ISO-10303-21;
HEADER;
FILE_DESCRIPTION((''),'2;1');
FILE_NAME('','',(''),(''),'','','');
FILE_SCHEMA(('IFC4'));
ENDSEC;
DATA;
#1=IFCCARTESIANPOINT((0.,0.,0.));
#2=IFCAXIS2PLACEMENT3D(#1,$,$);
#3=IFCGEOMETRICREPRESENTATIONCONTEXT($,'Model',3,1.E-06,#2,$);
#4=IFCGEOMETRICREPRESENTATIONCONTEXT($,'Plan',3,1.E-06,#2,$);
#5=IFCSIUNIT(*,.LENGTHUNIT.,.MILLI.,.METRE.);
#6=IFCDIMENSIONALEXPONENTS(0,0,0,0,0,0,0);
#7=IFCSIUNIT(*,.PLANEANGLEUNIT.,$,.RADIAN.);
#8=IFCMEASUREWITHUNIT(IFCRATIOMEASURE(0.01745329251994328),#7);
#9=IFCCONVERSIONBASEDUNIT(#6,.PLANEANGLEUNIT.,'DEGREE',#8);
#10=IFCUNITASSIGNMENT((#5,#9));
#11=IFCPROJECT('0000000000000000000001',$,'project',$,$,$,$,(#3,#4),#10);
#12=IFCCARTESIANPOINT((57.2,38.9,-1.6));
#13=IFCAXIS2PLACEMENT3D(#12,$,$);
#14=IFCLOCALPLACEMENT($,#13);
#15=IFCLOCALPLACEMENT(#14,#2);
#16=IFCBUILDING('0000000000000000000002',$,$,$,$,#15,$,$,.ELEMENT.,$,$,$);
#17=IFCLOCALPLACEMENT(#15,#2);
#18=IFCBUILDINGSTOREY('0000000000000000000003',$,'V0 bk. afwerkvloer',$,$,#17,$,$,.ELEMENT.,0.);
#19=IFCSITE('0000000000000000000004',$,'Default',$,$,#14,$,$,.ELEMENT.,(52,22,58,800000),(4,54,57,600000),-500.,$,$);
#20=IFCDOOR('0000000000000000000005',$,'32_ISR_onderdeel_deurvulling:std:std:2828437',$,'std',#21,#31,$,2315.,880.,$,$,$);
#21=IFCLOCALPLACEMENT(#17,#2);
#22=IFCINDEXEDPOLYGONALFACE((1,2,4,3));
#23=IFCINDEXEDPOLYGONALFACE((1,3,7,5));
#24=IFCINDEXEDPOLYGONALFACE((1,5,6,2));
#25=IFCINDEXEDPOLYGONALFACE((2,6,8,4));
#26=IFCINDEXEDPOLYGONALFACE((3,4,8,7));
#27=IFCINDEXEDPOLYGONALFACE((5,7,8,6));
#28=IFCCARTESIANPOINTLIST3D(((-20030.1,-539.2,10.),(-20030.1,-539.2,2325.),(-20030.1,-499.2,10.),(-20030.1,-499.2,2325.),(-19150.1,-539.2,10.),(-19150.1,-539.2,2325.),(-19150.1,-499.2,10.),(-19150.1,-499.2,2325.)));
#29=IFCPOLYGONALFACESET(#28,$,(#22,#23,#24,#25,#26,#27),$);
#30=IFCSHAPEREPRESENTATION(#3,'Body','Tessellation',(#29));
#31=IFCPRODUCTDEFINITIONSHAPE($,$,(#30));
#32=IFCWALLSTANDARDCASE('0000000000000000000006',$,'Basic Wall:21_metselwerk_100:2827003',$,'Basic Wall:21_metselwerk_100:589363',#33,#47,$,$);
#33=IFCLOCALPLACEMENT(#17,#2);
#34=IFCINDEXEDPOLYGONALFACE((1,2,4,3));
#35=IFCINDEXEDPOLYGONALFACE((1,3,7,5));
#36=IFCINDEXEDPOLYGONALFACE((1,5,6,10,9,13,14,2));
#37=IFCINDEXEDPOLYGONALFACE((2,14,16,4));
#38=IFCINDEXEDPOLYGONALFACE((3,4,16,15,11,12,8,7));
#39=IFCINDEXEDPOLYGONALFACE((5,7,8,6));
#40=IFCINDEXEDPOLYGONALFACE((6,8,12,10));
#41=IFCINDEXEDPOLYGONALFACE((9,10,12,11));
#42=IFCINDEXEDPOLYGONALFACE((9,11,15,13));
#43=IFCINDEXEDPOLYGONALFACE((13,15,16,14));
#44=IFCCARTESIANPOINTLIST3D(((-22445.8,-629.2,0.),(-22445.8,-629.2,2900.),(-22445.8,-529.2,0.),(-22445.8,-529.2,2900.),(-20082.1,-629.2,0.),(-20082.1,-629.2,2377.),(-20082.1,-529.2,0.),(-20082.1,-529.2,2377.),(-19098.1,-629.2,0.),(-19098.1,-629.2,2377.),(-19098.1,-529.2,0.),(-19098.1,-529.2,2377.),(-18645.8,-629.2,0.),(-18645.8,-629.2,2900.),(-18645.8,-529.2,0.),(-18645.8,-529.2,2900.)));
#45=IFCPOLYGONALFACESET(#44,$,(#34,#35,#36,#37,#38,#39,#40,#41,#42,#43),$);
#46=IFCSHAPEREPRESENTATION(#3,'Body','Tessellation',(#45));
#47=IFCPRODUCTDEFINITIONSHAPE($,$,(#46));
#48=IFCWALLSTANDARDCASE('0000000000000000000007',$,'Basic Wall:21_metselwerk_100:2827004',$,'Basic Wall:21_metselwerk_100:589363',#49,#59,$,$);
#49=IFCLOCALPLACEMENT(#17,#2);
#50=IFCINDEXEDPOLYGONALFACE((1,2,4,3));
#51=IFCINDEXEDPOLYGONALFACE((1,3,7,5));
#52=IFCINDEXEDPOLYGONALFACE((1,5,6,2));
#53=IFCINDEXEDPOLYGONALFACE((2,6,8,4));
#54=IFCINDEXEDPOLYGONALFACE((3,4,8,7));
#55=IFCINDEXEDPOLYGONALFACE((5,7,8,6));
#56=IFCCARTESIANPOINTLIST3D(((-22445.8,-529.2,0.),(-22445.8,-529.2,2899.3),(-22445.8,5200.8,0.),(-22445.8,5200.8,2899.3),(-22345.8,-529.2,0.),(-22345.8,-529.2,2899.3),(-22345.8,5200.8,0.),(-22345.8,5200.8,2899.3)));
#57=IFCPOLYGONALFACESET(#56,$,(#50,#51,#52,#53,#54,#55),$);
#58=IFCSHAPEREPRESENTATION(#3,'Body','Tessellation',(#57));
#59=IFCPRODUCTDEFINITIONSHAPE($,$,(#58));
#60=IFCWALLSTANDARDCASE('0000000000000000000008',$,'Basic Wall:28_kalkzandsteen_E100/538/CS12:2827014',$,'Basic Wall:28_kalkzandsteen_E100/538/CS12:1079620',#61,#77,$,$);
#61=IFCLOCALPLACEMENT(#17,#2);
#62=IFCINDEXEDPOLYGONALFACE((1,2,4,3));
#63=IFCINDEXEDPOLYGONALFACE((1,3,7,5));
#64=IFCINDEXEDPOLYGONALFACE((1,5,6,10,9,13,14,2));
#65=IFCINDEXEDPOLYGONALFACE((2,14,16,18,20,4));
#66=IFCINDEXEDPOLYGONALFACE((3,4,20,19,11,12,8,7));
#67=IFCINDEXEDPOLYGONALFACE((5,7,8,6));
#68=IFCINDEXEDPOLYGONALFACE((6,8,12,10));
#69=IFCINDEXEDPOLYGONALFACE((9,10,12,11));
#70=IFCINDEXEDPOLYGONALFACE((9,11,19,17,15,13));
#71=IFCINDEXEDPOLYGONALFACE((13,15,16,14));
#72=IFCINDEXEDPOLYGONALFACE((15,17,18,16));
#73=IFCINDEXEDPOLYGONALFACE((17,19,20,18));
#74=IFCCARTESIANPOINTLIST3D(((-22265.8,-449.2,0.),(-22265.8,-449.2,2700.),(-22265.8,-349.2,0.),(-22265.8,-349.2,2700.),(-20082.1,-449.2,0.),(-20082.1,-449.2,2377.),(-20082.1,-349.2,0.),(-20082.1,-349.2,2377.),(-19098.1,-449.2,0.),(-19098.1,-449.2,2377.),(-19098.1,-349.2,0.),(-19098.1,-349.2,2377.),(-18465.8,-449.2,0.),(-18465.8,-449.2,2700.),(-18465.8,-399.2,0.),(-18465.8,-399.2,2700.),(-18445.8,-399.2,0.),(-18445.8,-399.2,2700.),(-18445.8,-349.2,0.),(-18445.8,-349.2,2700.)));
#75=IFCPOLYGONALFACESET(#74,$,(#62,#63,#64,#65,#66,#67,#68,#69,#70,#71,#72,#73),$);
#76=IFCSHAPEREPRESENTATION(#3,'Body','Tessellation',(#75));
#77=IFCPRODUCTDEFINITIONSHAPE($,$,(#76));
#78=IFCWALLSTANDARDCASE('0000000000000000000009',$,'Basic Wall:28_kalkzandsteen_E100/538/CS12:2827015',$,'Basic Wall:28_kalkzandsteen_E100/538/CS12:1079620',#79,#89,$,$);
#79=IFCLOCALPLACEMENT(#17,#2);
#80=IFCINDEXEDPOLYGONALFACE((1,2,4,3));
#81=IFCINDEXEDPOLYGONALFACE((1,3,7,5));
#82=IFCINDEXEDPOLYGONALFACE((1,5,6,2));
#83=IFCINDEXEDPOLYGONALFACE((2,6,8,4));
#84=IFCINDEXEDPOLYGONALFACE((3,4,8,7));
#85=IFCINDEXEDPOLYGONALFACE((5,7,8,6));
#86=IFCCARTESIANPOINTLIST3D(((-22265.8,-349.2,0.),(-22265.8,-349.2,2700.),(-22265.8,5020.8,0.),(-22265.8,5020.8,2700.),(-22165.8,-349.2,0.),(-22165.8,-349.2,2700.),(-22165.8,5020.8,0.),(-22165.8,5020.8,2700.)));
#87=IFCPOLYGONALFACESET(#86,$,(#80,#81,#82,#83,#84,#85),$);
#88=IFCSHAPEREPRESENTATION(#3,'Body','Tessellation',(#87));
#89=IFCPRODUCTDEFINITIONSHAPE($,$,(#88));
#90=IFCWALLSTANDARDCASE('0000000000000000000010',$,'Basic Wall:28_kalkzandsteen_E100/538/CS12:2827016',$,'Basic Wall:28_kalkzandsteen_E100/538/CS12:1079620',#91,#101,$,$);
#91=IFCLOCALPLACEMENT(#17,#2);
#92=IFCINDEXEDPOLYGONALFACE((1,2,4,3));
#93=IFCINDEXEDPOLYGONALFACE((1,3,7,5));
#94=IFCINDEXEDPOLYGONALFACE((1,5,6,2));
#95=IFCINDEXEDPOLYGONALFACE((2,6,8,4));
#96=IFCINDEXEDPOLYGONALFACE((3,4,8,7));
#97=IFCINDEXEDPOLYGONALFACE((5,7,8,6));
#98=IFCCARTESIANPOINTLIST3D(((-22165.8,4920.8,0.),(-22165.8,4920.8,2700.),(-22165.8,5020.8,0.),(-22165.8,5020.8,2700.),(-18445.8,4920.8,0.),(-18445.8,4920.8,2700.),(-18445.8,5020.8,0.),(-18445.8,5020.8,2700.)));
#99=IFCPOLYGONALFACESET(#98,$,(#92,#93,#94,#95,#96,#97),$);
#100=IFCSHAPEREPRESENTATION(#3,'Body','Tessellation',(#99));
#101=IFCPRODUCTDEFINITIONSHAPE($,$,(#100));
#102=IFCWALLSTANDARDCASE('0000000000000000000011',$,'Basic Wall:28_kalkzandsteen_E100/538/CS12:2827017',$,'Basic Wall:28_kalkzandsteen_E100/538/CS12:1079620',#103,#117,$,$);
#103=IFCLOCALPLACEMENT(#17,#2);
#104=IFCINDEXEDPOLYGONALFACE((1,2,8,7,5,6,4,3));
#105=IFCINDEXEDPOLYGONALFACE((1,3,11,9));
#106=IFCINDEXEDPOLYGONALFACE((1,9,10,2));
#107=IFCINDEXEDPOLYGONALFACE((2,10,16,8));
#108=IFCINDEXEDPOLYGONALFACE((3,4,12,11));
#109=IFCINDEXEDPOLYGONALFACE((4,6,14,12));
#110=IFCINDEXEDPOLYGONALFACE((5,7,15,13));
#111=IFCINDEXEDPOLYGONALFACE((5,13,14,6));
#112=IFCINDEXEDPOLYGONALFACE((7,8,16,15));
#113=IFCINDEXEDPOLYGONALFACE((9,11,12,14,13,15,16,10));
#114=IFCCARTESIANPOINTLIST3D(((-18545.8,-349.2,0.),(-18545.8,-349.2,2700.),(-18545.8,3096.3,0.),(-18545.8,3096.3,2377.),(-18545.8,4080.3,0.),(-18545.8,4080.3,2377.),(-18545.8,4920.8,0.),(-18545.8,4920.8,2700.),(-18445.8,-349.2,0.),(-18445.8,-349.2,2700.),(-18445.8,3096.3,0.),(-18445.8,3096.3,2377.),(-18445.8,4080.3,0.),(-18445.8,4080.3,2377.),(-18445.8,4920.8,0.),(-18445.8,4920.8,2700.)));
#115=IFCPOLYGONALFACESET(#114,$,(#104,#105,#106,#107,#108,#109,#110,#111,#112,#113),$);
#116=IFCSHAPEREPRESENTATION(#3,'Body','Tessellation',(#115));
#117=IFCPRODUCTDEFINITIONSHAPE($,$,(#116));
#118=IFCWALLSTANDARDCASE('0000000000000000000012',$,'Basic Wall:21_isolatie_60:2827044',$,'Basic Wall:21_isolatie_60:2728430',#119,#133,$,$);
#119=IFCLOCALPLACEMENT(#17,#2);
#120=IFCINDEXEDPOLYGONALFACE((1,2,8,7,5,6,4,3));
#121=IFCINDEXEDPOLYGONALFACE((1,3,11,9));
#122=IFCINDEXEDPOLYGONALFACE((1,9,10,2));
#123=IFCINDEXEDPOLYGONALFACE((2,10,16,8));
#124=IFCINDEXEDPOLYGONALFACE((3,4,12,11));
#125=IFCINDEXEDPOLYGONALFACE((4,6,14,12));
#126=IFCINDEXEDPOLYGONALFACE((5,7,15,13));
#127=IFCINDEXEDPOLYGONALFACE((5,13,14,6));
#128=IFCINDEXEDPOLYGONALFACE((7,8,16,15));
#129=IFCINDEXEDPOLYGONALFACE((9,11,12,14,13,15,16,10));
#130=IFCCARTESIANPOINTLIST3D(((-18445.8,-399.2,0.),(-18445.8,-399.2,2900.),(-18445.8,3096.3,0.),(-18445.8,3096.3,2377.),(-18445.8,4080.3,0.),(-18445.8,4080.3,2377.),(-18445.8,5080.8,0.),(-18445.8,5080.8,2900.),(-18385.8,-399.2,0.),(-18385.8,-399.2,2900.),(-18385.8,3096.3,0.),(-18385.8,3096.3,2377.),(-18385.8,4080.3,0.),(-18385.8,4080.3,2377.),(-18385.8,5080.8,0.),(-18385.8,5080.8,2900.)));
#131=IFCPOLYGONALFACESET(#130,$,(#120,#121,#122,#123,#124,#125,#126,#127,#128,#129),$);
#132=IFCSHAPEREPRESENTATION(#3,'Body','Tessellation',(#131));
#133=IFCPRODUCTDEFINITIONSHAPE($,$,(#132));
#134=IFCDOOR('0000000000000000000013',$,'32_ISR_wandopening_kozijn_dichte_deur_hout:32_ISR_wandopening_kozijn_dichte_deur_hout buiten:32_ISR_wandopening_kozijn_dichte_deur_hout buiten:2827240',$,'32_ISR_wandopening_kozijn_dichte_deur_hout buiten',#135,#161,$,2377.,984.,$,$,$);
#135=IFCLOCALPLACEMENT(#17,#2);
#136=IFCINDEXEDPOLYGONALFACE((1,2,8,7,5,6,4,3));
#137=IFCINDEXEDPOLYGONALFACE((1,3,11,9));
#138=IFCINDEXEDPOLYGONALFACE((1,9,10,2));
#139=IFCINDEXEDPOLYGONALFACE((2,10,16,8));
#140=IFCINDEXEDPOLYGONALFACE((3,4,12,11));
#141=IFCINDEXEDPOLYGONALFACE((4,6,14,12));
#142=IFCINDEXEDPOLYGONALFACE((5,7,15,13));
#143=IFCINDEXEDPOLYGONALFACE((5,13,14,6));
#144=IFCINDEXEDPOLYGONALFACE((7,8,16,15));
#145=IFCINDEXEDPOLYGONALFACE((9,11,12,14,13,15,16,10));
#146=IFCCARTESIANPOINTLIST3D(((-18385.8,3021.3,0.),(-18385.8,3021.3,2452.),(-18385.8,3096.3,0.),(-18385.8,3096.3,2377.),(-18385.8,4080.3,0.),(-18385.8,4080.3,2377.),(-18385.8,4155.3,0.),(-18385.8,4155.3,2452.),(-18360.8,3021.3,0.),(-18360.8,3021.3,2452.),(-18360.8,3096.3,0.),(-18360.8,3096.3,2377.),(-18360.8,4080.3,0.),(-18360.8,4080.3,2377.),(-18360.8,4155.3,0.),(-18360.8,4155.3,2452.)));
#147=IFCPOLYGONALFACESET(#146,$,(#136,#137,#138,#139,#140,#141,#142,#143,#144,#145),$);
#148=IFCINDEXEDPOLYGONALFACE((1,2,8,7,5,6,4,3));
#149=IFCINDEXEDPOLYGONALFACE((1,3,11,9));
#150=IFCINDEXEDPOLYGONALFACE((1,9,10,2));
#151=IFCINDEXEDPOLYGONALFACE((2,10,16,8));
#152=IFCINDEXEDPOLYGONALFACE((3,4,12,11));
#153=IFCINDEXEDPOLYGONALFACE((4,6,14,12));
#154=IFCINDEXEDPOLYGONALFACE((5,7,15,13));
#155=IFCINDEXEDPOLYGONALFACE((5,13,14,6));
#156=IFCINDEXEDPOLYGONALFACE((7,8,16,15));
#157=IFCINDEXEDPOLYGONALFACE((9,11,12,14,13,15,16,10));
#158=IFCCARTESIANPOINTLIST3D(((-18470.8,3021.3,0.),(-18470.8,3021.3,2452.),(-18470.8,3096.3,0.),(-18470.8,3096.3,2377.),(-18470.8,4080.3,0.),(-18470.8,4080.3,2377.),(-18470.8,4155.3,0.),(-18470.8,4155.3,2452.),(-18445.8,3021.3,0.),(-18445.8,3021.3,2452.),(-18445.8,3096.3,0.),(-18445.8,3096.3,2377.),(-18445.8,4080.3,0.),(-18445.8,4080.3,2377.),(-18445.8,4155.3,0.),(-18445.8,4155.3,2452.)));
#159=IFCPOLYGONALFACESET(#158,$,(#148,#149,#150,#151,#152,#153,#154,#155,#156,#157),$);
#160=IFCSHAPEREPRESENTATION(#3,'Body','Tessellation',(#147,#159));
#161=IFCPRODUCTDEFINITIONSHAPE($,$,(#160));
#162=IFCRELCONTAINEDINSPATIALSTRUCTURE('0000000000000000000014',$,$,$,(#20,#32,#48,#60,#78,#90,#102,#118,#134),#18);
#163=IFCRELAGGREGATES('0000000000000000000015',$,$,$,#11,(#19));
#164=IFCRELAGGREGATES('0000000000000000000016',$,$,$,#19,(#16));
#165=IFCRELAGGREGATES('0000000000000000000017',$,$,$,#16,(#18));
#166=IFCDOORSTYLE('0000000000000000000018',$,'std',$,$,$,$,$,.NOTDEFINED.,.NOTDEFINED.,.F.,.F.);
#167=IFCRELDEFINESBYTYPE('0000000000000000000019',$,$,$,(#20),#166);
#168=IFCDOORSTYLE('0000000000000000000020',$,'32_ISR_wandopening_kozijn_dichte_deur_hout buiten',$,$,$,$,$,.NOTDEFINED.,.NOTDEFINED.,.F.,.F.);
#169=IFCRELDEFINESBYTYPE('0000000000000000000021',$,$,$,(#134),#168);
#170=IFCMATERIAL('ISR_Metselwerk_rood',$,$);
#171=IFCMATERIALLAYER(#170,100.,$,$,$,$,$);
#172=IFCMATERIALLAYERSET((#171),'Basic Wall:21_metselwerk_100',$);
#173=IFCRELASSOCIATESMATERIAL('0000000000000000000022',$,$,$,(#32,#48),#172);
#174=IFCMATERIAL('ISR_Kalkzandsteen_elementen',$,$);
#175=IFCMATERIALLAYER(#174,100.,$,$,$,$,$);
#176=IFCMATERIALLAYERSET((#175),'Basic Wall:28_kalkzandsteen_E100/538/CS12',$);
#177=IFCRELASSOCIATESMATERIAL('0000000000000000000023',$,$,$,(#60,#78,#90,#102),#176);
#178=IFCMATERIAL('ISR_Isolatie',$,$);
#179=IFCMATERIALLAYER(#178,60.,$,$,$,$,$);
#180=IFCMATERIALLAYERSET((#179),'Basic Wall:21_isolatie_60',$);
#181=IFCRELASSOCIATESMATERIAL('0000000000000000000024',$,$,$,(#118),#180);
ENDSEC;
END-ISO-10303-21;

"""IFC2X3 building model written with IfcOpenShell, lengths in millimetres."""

from ifc_helpers import new_model, entity, si_unit, converted_unit, frame, frame_2d, origin, origin_2d_with_axis, place, context, project, spatial, polyline, rectangle, outline, extrude, source, transform, mapped, material, layer, layer_set, layer_usage, type_object, type_shapes, element, fill, save


model = new_model("IFC2X3")

# Units and contexts
model_context = context("Model", 3, precision=1e-06, world=origin())
plan_context = context("Plan", 3, precision=1e-06, world=origin())
ifc_project = project(units=[si_unit("LENGTHUNIT", "METRE", prefix="MILLI"), converted_unit("PLANEANGLEUNIT", "DEGREE", entity("IfcRatioMeasure", 0.01745329251994328), si_unit("PLANEANGLEUNIT", "RADIAN"), dimensions=[0, 0, 0, 0, 0, 0, 0])], contexts=[model_context, plan_context])

# Site, building, storey
site_placement = place(None, frame((57.2, 38.9, -1.6)))
site = spatial("IfcSite", under=ifc_project, at=site_placement, Name="Default", CompositionType="ELEMENT", RefLatitude=(52, 22, 58, 800000), RefLongitude=(4, 54, 57, 600000), RefElevation=-500.0)
building_placement = place(site_placement, origin())
building = spatial("IfcBuilding", under=site, at=building_placement, CompositionType="ELEMENT")
storey_placement = place(building_placement, origin())
storey = spatial("IfcBuildingStorey", under=building, at=storey_placement, Name="V0 bk. afwerkvloer", CompositionType="ELEMENT", Elevation=0.0)

# Door
door_style_1 = type_object("IfcDoorStyle", Name="std", ConstructionType="NOTDEFINED", OperationType="NOTDEFINED", ParameterTakesPrecedence=False, Sizeable=False)
shared_shape_1 = source(origin(), model_context, "Body", "SweptSolid", [
    extrude(rectangle(XDim=40.0, YDim=880.0, at=origin_2d_with_axis()), frame((0.0, -34.0, 0.0), z_axis=(0.0, 0.0, 1.0), x_axis=(0.0, -1.0, 0.0)), (0.0, 0.0, 1.0), 2315.0),
])
type_shapes(door_style_1, [shared_shape_1])
door_1_placement = place(storey_placement, frame((-19590.1, -553.2, 10.0), z_axis=(0.0, 0.0, 1.0), x_axis=(-1.0, 0.0, 0.0)))
element("IfcDoor", 1, at=door_1_placement, inside=storey, type_object=door_style_1, Name="32_ISR_onderdeel_deurvulling:std:std:2828437", ObjectType="std", OverallHeight=2315.0, OverallWidth=880.0, context=model_context, shape_type="MappedRepresentation", body=[
    mapped(shared_shape_1, transform((0.0, 0.0, 0.0), scale=1.0)),
])

# Wall, opening
ifc_material_1 = material(Name="ISR_Metselwerk_rood")
ifc_layer_1 = layer(ifc_material_1, 100.0)
ifc_layer_set_1 = layer_set([ifc_layer_1], Name="Basic Wall:21_metselwerk_100")
ifc_layer_usage_1 = layer_usage(ifc_layer_set_1, "AXIS2", "POSITIVE", -50.0)
wall_1_placement = place(storey_placement, frame((-18645.8, -579.2, 0.0), z_axis=(0.0, 0.0, 1.0), x_axis=(-1.0, 0.0, 0.0)))
wall_1 = element("IfcWallStandardCase", 2, at=wall_1_placement, inside=storey, material=ifc_layer_usage_1, Name="Basic Wall:21_metselwerk_100:2827003", ObjectType="Basic Wall:21_metselwerk_100:589363", context=model_context, shape_type="SweptSolid", body=[
    extrude(rectangle(XDim=3800.0, YDim=100.0, at=frame_2d((1900.0, 0.0), x_axis=(-1.0, 0.0))), origin(), (0.0, 0.0, 1.0), 2900.0),
])
opening_1_placement = place(wall_1_placement, origin())
element("IfcOpeningElement", 3, at=opening_1_placement, cuts=wall_1, ObjectType="Opening", context=model_context, shape_type="SweptSolid", body=[
    extrude(rectangle(XDim=2377.0, YDim=984.0, at=frame_2d((0.0, 0.0), x_axis=(0.0, 1.0))), frame((944.2, -1654.0, 1188.5), z_axis=(0.0, 1.0, 0.0), x_axis=(-1.0, 0.0, 0.0)), (0.0, 0.0, 1.0), 3048.0),
])

# Wall
ifc_layer_usage_2 = layer_usage(ifc_layer_set_1, "AXIS2", "POSITIVE", -50.0)
wall_2_placement = place(storey_placement, frame((-22395.8, -529.2, 0.0), z_axis=(0.0, 0.0, 1.0), x_axis=(0.0, 1.0, 0.0)))
element("IfcWallStandardCase", 4, at=wall_2_placement, inside=storey, material=ifc_layer_usage_2, Name="Basic Wall:21_metselwerk_100:2827004", ObjectType="Basic Wall:21_metselwerk_100:589363", context=model_context, shape_type="SweptSolid", body=[
    extrude(rectangle(XDim=5730.0, YDim=100.0, at=frame_2d((2865.0, 0.0), x_axis=(-1.0, 0.0))), origin(), (0.0, 0.0, 1.0), 2899.3),
])

# Wall, opening
ifc_material_2 = material(Name="ISR_Kalkzandsteen_elementen")
ifc_layer_2 = layer(ifc_material_2, 100.0)
ifc_layer_set_2 = layer_set([ifc_layer_2], Name="Basic Wall:28_kalkzandsteen_E100/538/CS12")
ifc_layer_usage_3 = layer_usage(ifc_layer_set_2, "AXIS2", "POSITIVE", -50.0)
wall_3_placement = place(storey_placement, frame((-18445.8, -399.2, 0.0), z_axis=(0.0, 0.0, 1.0), x_axis=(-1.0, 0.0, 0.0)))
wall_3 = element("IfcWallStandardCase", 5, at=wall_3_placement, inside=storey, material=ifc_layer_usage_3, Name="Basic Wall:28_kalkzandsteen_E100/538/CS12:2827014", ObjectType="Basic Wall:28_kalkzandsteen_E100/538/CS12:1079620", context=model_context, shape_type="SweptSolid", body=[
    extrude(outline(polyline([(0.0, -50.0), (100.0, -50.0), (3720.0, -50.0), (3820.0, -50.0), (3820.0, 50.0), (20.0, 50.0), (20.0, 0.0), (0.0, 0.0), (0.0, -50.0)])), origin(), (0.0, 0.0, 1.0), 2700.0),
])
opening_2_placement = place(wall_3_placement, origin())
element("IfcOpeningElement", 6, at=opening_2_placement, cuts=wall_3, ObjectType="Opening", context=model_context, shape_type="SweptSolid", body=[
    extrude(rectangle(XDim=2377.0, YDim=984.0, at=frame_2d((0.0, 0.0), x_axis=(0.0, 1.0))), frame((1144.2, -1474.0, 1188.5), z_axis=(0.0, 1.0, 0.0), x_axis=(-1.0, 0.0, 0.0)), (0.0, 0.0, 1.0), 3048.0),
])

# Walls
ifc_layer_usage_4 = layer_usage(ifc_layer_set_2, "AXIS2", "POSITIVE", -50.0)
wall_4_placement = place(storey_placement, frame((-22215.8, -349.2, 0.0), z_axis=(0.0, 0.0, 1.0), x_axis=(0.0, 1.0, 0.0)))
element("IfcWallStandardCase", 7, at=wall_4_placement, inside=storey, material=ifc_layer_usage_4, Name="Basic Wall:28_kalkzandsteen_E100/538/CS12:2827015", ObjectType="Basic Wall:28_kalkzandsteen_E100/538/CS12:1079620", context=model_context, shape_type="SweptSolid", body=[
    extrude(rectangle(XDim=5370.0, YDim=100.0, at=frame_2d((2685.0, 0.0), x_axis=(-1.0, 0.0))), origin(), (0.0, 0.0, 1.0), 2700.0),
])
ifc_layer_usage_5 = layer_usage(ifc_layer_set_2, "AXIS2", "POSITIVE", -50.0)
wall_5_placement = place(storey_placement, frame((-22165.8, 4970.8, 0.0)))
element("IfcWallStandardCase", 8, at=wall_5_placement, inside=storey, material=ifc_layer_usage_5, Name="Basic Wall:28_kalkzandsteen_E100/538/CS12:2827016", ObjectType="Basic Wall:28_kalkzandsteen_E100/538/CS12:1079620", context=model_context, shape_type="SweptSolid", body=[
    extrude(rectangle(XDim=3720.0, YDim=100.0, at=frame_2d((1860.0, 0.0), x_axis=(-1.0, 0.0))), origin(), (0.0, 0.0, 1.0), 2700.0),
])

# Wall, opening
ifc_layer_usage_6 = layer_usage(ifc_layer_set_2, "AXIS2", "POSITIVE", -50.0)
wall_6_placement = place(storey_placement, frame((-18495.8, 4920.8, 0.0), z_axis=(0.0, 0.0, 1.0), x_axis=(0.0, -1.0, 0.0)))
wall_6 = element("IfcWallStandardCase", 9, at=wall_6_placement, inside=storey, material=ifc_layer_usage_6, Name="Basic Wall:28_kalkzandsteen_E100/538/CS12:2827017", ObjectType="Basic Wall:28_kalkzandsteen_E100/538/CS12:1079620", context=model_context, shape_type="SweptSolid", body=[
    extrude(rectangle(XDim=5270.0, YDim=100.0, at=frame_2d((2635.0, 0.0), x_axis=(-1.0, 0.0))), origin(), (0.0, 0.0, 1.0), 2700.0),
])
opening_3_placement = place(wall_6_placement, origin())
element("IfcOpeningElement", 10, at=opening_3_placement, cuts=wall_6, ObjectType="Opening", context=model_context, shape_type="SweptSolid", body=[
    extrude(rectangle(XDim=2377.0, YDim=984.0, at=frame_2d((0.0, 0.0), x_axis=(0.0, 1.0))), frame((1332.4, -1474.0, 1188.5), z_axis=(0.0, 1.0, 0.0), x_axis=(-1.0, 0.0, 0.0)), (0.0, 0.0, 1.0), 3048.0),
])

# Wall, opening, door
ifc_material_3 = material(Name="ISR_Isolatie")
ifc_layer_3 = layer(ifc_material_3, 60.0)
ifc_layer_set_3 = layer_set([ifc_layer_3], Name="Basic Wall:21_isolatie_60")
ifc_layer_usage_7 = layer_usage(ifc_layer_set_3, "AXIS2", "POSITIVE", -30.0)
wall_7_placement = place(storey_placement, frame((-18415.8, 5080.8, 0.0), z_axis=(0.0, 0.0, 1.0), x_axis=(0.0, -1.0, 0.0)))
wall_7 = element("IfcWallStandardCase", 11, at=wall_7_placement, inside=storey, material=ifc_layer_usage_7, Name="Basic Wall:21_isolatie_60:2827044", ObjectType="Basic Wall:21_isolatie_60:2728430", context=model_context, shape_type="SweptSolid", body=[
    extrude(rectangle(XDim=5480.0, YDim=60.0, at=frame_2d((2740.0, 0.0), x_axis=(-1.0, 0.0))), origin(), (0.0, 0.0, 1.0), 2900.0),
])
opening_4_placement = place(wall_7_placement, frame((1000.4, -30.0, 0.0)))
opening_4 = element("IfcOpeningElement", 12, at=opening_4_placement, cuts=wall_7, ObjectType="Opening", context=model_context, shape_type="SweptSolid", body=[
    extrude(rectangle(XDim=2377.0, YDim=984.0, at=frame_2d((1188.5, 492.0), x_axis=(1.0, 0.0))), frame((0.0, 0.0, 0.0), z_axis=(0.0, 1.0, 0.0), x_axis=(0.0, 0.0, 1.0)), (0.0, 0.0, 1.0), 60.0),
])
door_style_2 = type_object("IfcDoorStyle", Name="32_ISR_wandopening_kozijn_dichte_deur_hout buiten", ConstructionType="NOTDEFINED", OperationType="NOTDEFINED", ParameterTakesPrecedence=False, Sizeable=False)
shared_shape_2 = source(origin(), model_context, "Body", "SweptSolid", [
    extrude(outline(polyline([(-1169.7, 492.0), (1207.2, 492.0), (1207.2, 567.0), (-1244.7, 567.0), (-1244.7, -567.0), (1207.2, -567.0), (1207.2, -492.0), (-1169.7, -492.0), (-1169.7, 492.0)])), frame((492.0, 60.0, 1207.2), z_axis=(0.0, 1.0, 0.0), x_axis=(0.0, 0.0, -1.0)), (0.0, 0.0, 1.0), 25.0),
    extrude(outline(polyline([(-567.0, -1244.7), (567.0, -1244.7), (567.0, 1207.2), (492.0, 1207.2), (492.0, -1169.7), (-492.0, -1169.7), (-492.0, 1207.2), (-567.0, 1207.2), (-567.0, -1244.7)])), frame((492.0, -25.0, 1207.2), z_axis=(0.0, 1.0, 0.0), x_axis=(1.0, 0.0, 0.0)), (0.0, 0.0, 1.0), 25.0),
])
type_shapes(door_style_2, [shared_shape_2])
door_2_placement = place(opening_4_placement, origin())
door_2 = element("IfcDoor", 13, at=door_2_placement, inside=storey, type_object=door_style_2, Name="32_ISR_wandopening_kozijn_dichte_deur_hout:32_ISR_wandopening_kozijn_dichte_deur_hout buiten:32_ISR_wandopening_kozijn_dichte_deur_hout buiten:2827240", ObjectType="32_ISR_wandopening_kozijn_dichte_deur_hout buiten", OverallHeight=2377.0, OverallWidth=984.0, context=model_context, shape_type="MappedRepresentation", body=[
    mapped(shared_shape_2, transform((0.0, 0.0, 0.0), scale=1.0)),
])
fill(opening_4, door_2)

save(model, "model.ifc")
